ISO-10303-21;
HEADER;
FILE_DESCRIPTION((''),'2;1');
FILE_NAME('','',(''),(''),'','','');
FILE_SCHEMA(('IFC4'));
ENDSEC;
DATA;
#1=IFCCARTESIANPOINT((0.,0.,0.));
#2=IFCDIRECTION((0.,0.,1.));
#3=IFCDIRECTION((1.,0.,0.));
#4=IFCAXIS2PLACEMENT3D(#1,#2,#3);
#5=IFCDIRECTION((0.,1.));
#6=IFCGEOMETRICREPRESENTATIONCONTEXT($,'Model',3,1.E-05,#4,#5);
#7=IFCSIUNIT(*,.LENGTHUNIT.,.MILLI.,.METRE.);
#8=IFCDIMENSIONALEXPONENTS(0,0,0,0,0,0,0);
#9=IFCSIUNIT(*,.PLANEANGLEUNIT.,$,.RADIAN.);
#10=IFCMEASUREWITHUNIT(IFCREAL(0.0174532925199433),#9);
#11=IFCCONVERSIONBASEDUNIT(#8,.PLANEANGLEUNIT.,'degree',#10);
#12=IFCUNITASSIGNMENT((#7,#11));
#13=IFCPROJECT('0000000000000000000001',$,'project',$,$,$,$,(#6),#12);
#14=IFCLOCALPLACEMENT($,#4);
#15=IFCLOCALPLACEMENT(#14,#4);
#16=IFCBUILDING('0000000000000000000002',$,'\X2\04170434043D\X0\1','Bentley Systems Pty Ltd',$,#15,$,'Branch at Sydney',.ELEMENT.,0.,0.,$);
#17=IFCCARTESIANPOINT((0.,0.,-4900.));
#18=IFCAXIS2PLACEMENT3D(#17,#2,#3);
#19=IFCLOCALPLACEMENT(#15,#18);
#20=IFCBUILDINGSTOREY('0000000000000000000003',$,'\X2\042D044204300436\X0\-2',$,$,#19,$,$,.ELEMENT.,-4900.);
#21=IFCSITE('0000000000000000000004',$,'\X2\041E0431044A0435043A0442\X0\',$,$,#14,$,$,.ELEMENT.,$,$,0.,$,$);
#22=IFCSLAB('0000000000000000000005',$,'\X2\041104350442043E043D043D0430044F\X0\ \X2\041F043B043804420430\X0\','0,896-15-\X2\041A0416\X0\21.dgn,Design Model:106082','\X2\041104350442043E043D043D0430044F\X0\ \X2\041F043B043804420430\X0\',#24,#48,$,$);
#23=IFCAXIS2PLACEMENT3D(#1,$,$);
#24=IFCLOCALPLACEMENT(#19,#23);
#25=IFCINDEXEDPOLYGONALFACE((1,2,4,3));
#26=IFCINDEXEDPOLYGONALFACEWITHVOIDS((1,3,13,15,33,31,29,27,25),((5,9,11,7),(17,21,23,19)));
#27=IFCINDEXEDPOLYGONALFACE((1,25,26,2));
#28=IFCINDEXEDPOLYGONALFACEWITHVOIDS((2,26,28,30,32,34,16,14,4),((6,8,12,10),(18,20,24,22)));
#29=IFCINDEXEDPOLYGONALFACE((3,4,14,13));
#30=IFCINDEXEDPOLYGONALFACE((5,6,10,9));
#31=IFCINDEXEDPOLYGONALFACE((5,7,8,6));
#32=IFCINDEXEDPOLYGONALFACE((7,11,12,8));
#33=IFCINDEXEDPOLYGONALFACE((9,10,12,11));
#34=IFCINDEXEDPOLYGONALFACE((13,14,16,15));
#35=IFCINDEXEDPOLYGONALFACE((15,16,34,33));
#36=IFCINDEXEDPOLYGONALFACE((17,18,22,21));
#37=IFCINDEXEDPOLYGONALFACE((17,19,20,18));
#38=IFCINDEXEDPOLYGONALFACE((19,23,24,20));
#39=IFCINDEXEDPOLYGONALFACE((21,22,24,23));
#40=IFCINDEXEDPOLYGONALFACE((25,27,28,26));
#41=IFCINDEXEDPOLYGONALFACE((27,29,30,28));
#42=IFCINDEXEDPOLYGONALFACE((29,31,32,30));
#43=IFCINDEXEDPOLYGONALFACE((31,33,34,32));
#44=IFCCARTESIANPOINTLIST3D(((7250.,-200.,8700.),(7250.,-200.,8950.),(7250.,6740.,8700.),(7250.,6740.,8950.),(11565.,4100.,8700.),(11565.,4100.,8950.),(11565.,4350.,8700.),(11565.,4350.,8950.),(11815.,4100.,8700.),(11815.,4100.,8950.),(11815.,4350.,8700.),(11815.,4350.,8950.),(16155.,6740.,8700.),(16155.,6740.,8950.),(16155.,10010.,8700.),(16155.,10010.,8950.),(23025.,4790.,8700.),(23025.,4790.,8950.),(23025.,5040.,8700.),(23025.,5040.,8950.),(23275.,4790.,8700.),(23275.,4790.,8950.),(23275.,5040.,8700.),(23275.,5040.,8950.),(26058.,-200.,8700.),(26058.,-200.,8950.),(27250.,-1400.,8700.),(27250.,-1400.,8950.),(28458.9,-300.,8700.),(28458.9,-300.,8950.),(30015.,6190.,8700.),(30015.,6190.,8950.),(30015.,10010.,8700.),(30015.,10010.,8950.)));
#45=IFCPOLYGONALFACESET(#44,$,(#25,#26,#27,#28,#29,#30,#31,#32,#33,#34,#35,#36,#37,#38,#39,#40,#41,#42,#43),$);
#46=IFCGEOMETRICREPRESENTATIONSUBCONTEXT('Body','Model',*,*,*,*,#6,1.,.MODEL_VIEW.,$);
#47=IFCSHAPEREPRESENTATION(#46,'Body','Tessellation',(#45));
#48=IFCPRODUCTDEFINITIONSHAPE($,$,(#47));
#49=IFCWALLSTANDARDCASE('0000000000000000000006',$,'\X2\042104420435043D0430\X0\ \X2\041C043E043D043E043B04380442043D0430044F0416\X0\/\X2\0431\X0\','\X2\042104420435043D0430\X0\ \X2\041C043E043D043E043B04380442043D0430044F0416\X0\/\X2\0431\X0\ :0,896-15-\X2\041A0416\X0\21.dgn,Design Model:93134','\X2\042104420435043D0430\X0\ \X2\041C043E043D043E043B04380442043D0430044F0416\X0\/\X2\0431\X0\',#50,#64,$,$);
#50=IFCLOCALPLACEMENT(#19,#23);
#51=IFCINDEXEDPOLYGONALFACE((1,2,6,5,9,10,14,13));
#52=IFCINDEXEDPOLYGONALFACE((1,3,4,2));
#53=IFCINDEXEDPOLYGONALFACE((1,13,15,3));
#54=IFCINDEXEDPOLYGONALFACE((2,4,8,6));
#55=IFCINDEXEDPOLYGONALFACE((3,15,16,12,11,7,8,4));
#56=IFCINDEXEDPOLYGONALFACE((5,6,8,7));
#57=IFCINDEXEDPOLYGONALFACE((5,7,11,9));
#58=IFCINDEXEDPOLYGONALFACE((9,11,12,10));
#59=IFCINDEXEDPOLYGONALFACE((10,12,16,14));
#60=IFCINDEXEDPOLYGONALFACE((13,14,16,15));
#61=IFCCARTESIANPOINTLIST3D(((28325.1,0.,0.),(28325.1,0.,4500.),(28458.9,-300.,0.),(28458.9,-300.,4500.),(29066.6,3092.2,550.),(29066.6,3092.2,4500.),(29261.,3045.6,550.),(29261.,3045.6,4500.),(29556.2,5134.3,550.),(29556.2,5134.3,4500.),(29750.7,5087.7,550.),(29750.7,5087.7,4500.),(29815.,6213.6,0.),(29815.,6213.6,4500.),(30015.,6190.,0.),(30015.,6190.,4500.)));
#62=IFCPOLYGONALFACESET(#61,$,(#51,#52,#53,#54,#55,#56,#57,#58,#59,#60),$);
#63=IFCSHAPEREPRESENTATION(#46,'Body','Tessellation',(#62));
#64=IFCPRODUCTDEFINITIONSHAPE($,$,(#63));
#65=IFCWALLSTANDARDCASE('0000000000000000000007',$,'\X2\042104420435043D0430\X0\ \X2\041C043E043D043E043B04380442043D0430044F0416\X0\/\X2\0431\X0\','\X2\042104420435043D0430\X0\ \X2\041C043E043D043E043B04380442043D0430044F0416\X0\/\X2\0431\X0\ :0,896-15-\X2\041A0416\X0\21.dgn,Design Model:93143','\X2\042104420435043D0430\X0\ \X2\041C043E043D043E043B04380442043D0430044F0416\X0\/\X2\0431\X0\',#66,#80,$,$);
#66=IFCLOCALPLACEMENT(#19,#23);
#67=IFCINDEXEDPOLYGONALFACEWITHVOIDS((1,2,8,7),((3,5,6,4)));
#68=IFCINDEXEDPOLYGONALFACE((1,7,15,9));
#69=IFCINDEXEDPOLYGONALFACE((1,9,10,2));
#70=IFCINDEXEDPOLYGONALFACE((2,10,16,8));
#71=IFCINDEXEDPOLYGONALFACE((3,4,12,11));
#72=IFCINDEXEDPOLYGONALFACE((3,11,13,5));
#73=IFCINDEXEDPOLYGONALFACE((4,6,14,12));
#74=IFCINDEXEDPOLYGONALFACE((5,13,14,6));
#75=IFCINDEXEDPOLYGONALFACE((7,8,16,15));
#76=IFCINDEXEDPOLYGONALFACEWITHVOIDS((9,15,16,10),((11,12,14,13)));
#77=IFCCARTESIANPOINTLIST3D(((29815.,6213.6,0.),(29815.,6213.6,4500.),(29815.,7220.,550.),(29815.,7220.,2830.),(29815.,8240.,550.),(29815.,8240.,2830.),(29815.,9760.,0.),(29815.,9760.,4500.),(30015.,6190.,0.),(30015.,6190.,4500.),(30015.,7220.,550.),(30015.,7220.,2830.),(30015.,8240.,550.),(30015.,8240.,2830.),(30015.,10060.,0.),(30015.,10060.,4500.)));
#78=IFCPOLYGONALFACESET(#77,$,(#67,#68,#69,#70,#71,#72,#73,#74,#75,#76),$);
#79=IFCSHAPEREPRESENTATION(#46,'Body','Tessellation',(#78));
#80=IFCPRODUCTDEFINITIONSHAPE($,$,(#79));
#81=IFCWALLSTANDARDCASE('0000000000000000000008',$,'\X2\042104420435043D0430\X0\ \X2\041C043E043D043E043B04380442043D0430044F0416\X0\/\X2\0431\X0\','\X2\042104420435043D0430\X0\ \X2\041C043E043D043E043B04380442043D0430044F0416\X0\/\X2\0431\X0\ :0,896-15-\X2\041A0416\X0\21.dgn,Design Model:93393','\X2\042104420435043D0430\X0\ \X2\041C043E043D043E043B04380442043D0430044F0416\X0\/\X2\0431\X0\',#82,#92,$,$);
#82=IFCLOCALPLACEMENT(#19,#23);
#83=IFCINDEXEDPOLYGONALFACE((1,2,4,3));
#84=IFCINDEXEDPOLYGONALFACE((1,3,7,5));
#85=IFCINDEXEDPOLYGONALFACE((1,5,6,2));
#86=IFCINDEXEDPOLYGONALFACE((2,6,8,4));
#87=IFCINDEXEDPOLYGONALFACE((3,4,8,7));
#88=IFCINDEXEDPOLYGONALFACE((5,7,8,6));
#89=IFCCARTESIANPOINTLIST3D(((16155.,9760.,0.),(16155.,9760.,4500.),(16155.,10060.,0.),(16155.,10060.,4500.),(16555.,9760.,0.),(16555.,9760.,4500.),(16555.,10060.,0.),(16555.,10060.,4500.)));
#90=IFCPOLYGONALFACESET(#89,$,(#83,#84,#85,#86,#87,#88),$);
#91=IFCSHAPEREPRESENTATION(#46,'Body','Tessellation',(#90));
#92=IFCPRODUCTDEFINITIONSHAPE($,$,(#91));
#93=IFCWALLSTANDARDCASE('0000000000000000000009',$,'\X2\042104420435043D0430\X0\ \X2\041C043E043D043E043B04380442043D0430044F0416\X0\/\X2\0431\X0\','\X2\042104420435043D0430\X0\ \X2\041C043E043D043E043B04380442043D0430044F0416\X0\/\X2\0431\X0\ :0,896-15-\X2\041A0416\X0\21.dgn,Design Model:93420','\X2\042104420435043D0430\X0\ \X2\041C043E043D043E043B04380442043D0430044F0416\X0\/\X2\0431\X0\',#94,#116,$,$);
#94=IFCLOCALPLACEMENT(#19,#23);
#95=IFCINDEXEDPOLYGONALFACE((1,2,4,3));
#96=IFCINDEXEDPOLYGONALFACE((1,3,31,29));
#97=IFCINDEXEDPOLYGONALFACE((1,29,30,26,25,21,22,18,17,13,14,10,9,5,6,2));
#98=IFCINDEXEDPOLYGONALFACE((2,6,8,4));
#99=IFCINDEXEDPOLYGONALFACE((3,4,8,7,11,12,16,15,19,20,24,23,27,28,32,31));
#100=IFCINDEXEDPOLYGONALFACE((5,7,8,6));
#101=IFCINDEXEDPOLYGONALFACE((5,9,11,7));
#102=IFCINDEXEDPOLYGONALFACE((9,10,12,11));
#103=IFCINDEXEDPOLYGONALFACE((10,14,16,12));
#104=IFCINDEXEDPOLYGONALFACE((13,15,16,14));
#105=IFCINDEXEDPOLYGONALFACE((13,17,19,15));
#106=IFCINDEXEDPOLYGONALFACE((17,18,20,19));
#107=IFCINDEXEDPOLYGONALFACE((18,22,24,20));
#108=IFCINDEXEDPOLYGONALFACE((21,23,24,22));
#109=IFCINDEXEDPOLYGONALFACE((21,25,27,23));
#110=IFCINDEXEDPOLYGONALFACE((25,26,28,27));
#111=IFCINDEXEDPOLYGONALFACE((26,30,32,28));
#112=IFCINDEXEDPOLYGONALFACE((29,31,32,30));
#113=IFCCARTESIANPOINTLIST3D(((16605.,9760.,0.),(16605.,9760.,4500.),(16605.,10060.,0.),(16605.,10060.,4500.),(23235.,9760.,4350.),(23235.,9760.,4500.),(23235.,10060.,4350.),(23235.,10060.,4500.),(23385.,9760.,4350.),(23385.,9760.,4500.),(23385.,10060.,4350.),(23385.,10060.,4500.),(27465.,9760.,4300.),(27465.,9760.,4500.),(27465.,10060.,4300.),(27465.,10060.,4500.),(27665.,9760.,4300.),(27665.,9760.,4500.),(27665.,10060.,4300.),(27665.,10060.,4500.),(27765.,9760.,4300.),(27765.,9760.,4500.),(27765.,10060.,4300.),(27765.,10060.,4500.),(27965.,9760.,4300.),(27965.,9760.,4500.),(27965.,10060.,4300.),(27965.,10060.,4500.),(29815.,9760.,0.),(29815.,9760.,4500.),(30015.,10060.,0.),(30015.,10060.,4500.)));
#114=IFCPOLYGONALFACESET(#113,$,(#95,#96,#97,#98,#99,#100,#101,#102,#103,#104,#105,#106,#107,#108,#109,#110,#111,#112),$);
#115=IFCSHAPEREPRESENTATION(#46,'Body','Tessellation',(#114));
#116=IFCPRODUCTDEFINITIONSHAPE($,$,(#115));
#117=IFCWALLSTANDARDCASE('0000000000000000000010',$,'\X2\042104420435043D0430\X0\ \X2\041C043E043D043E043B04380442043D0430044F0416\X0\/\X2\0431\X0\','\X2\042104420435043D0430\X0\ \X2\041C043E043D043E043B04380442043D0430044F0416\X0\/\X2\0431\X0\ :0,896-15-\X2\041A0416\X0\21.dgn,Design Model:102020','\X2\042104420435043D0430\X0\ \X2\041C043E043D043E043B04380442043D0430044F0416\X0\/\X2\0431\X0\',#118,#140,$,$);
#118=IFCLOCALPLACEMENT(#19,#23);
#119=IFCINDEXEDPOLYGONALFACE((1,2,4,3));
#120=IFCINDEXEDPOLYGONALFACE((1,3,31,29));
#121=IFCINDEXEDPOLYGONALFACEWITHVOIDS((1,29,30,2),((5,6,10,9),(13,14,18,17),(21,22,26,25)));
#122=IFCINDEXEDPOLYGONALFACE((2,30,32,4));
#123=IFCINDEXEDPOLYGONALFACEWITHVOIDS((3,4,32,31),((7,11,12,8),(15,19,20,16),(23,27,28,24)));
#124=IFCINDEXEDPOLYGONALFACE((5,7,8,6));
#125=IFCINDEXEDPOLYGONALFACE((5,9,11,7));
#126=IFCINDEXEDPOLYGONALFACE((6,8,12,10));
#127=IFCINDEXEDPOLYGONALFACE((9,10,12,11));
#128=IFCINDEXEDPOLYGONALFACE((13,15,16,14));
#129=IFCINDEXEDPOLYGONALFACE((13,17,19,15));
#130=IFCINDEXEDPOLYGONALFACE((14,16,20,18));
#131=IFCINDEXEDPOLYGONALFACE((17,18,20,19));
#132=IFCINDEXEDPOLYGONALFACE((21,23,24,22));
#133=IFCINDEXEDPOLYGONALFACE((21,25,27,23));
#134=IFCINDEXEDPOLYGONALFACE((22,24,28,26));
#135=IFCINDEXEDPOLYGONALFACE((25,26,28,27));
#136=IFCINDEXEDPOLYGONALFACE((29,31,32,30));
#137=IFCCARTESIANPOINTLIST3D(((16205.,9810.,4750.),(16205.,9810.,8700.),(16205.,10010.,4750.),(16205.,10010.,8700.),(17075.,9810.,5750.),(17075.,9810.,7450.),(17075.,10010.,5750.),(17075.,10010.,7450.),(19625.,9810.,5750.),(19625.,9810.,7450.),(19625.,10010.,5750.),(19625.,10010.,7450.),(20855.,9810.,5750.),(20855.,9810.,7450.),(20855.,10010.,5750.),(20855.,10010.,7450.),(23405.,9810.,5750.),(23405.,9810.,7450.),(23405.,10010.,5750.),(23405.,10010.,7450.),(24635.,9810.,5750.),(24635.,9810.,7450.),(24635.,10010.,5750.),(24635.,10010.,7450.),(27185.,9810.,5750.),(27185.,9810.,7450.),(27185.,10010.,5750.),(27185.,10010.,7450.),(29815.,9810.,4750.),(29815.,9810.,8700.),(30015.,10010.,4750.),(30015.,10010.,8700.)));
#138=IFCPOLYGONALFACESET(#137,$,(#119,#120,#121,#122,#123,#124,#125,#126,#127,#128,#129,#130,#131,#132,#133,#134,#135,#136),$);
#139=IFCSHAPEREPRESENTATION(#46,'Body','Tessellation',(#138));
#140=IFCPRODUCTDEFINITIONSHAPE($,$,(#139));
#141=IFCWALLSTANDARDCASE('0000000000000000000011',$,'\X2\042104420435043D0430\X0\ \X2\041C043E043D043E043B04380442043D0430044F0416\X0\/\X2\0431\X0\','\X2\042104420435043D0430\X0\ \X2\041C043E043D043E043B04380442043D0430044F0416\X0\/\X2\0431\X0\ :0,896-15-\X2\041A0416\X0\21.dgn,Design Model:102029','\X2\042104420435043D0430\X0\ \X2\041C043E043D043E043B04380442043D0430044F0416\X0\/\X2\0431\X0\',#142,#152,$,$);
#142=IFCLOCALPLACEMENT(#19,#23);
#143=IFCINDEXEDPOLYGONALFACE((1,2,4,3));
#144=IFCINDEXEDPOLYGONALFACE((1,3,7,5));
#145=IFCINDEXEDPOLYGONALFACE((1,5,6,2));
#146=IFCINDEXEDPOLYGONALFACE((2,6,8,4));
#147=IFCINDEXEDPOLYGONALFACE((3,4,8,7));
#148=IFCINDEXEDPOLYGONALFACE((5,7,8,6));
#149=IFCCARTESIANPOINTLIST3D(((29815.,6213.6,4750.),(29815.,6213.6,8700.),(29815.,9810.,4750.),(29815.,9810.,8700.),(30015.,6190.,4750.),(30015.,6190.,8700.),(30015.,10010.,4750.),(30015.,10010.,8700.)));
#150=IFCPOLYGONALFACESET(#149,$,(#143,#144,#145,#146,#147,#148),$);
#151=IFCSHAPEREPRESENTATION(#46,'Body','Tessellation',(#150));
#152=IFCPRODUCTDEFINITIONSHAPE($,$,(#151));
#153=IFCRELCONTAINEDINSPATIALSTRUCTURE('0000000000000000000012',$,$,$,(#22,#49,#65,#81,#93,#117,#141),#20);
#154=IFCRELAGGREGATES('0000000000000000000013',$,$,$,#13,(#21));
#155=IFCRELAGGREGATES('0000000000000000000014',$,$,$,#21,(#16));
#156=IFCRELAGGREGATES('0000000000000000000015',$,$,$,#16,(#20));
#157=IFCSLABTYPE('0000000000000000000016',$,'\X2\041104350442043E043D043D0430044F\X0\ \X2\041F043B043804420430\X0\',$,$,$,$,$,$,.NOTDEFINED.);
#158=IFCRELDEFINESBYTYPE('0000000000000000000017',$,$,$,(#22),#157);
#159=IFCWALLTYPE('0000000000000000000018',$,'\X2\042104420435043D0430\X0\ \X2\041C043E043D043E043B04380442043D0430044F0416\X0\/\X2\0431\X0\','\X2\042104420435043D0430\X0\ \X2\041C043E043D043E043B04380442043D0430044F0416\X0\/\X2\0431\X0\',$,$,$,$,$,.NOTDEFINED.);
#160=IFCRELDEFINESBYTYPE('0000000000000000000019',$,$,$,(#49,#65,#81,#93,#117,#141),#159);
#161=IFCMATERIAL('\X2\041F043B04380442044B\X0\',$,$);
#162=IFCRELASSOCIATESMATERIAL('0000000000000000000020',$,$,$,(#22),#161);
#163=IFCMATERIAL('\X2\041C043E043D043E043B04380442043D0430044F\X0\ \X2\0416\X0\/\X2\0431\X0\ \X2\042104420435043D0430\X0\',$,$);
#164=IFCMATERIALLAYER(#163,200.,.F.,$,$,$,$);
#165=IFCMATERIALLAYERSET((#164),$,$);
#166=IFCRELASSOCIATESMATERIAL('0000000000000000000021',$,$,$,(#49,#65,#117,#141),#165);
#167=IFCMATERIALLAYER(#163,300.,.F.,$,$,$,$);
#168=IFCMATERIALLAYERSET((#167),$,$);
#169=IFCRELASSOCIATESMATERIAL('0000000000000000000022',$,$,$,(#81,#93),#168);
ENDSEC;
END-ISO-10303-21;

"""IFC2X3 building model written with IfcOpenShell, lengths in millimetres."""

from ifc_helpers import new_model, entity, si_unit, converted_unit, direction, frame, frame_2d, origin_with_axes, place, context, subcontext, project, spatial, polyline, rectangle, outline, extrude, material, layer, layer_set, layer_usage, type_object, element, save


model = new_model("IFC2X3")

# Units and contexts
model_context = context("Model", 3, precision=1e-05, world=origin_with_axes(), true_north=direction((0.0, 1.0)))
body_context = subcontext(model_context, "Body", "Model", "MODEL_VIEW", scale=1.0)
ifc_project = project(units=[si_unit("LENGTHUNIT", "METRE", prefix="MILLI"), converted_unit("PLANEANGLEUNIT", "degree", entity("IfcReal", 0.0174532925199433), si_unit("PLANEANGLEUNIT", "RADIAN"), dimensions=[0, 0, 0, 0, 0, 0, 0])], contexts=[model_context])

# Site, building, storey
site_placement = place(None, origin_with_axes())
site = spatial("IfcSite", under=ifc_project, at=site_placement, Name="Объект", CompositionType="ELEMENT", RefElevation=0.0)
building_placement = place(site_placement, origin_with_axes())
building = spatial("IfcBuilding", under=site, at=building_placement, Name="Здн1", Description="Bentley Systems Pty Ltd", LongName="Branch at Sydney", CompositionType="ELEMENT", ElevationOfRefHeight=0.0, ElevationOfTerrain=0.0)
storey_placement = place(building_placement, frame((0.0, 0.0, -4900.0), z_axis=(0.0, 0.0, 1.0), x_axis=(1.0, 0.0, 0.0)))
storey = spatial("IfcBuildingStorey", under=building, at=storey_placement, Name="Этаж-2", CompositionType="ELEMENT", Elevation=-4900.0)

# Slab, openings
ifc_material_1 = material(Name="Плиты")
slab_type = type_object("IfcSlabType", Name="Бетонная Плита", PredefinedType="NOTDEFINED")
slab_placement = place(storey_placement, frame((30015.0, 10010.0, 8950.0), z_axis=(0.0, 0.0, -1.0), x_axis=(0.0, -1.0, 0.0)))
slab = element("IfcSlab", 1, at=slab_placement, inside=storey, type_object=slab_type, material=ifc_material_1, Name="Бетонная Плита", Description="0,896-15-КЖ21.dgn,Design Model:106082", ObjectType="Бетонная Плита", context=body_context, shape_type="SweptSolid", body=[
    extrude(outline(polyline([(0.0, 0.0), (3820.0, 0.0), (10310.0, 1556.1), (11410.0, 2765.0), (10210.0, 3957.0), (10210.0, 22765.0), (3270.0, 22765.0), (3270.0, 13860.0), (0.0, 13860.0), (0.0, 0.0)])), origin_with_axes(), (0.0, 0.0, 1.0), 250.0),
])
opening_1_placement = place(slab_placement, frame((4970.0, 6740.0, 0.0), z_axis=(0.0, 0.0, 1.0), x_axis=(1.0, 0.0, 0.0)))
element("IfcOpeningElement", 2, at=opening_1_placement, cuts=slab, ObjectType="Opening", context=body_context, shape_type="SweptSolid", body=[
    extrude(rectangle(XDim=250.0, YDim=250.0, at=frame_2d((-125.0, 125.0), x_axis=(0.0, 1.0))), frame((0.0, 0.0, 375.0), z_axis=(0.0, 0.0, -1.0), x_axis=(-1.0, 0.0, 0.0)), (0.0, 0.0, 1.0), 750.0),
])
opening_2_placement = place(slab_placement, frame((5660.0, 18200.0, 0.0), z_axis=(0.0, 0.0, 1.0), x_axis=(1.0, 0.0, 0.0)))
element("IfcOpeningElement", 3, at=opening_2_placement, cuts=slab, ObjectType="Opening", context=body_context, shape_type="SweptSolid", body=[
    extrude(rectangle(XDim=250.0, YDim=250.0, at=frame_2d((-125.0, 125.0), x_axis=(0.0, 1.0))), frame((0.0, 0.0, 375.0), z_axis=(0.0, 0.0, -1.0), x_axis=(-1.0, 0.0, 0.0)), (0.0, 0.0, 1.0), 750.0),
])

# Walls, openings
ifc_material_2 = material(Name="Монолитная Ж/б Стена")
ifc_layer_1 = layer(ifc_material_2, 200.0, ventilated=False)
ifc_layer_set_1 = layer_set([ifc_layer_1])
ifc_layer_usage_1 = layer_usage(ifc_layer_set_1, "AXIS2", "POSITIVE", 0.0)
wall_type = type_object("IfcWallType", Name="Стена МонолитнаяЖ/б", Description="Стена МонолитнаяЖ/б", PredefinedType="NOTDEFINED")
wall_1_placement = place(storey_placement, frame((28458.9, -300.0, 0.0), z_axis=(0.0, 0.0, 1.0), x_axis=(0.233165, 0.972437, 0.0)))
wall_1 = element("IfcWallStandardCase", 4, at=wall_1_placement, inside=storey, type_object=wall_type, material=ifc_layer_usage_1, Name="Стена МонолитнаяЖ/б", Description="Стена МонолитнаяЖ/б :0,896-15-КЖ21.dgn,Design Model:93134", ObjectType="Стена МонолитнаяЖ/б", context=body_context, shape_type="SweptSolid", body=[
    extrude(outline(polyline([(6650.3, 200.0), (260.6, 200.0), (0.0, 0.0), (6673.9, 0.0), (6650.3, 200.0)])), origin_with_axes(), (0.0, 0.0, 1.0), 4500.0),
])
opening_3_placement = place(wall_1_placement, frame((3440.4, 0.0, 550.0), z_axis=(0.0, 0.0, 1.0), x_axis=(1.0, 0.0, 0.0)))
element("IfcOpeningElement", 5, at=opening_3_placement, cuts=wall_1, ObjectType="Opening", context=body_context, shape_type="SweptSolid", body=[
    extrude(rectangle(XDim=3950.0, YDim=2100.0, at=frame_2d((-1050.0, 1975.0), x_axis=(0.0, -1.0))), frame((0.0, 0.0, 0.0), z_axis=(0.0, 1.0, 0.0), x_axis=(-1.0, 0.0, 0.0)), (0.0, 0.0, 1.0), 200.0),
])
wall_2_placement = place(storey_placement, frame((30015.0, 6190.0, 0.0), z_axis=(0.0, 0.0, 1.0), x_axis=(0.0, 1.0, 0.0)))
wall_2 = element("IfcWallStandardCase", 6, at=wall_2_placement, inside=storey, type_object=wall_type, material=ifc_layer_usage_1, Name="Стена МонолитнаяЖ/б", Description="Стена МонолитнаяЖ/б :0,896-15-КЖ21.dgn,Design Model:93143", ObjectType="Стена МонолитнаяЖ/б", context=body_context, shape_type="SweptSolid", body=[
    extrude(outline(polyline([(3570.0, 200.0), (23.6, 200.0), (0.0, 0.0), (3870.0, 0.0), (3570.0, 200.0)])), origin_with_axes(), (0.0, 0.0, 1.0), 4500.0),
])
opening_4_placement = place(wall_2_placement, frame((1030.0, 0.0, 550.0), z_axis=(0.0, 0.0, 1.0), x_axis=(1.0, 0.0, 0.0)))
element("IfcOpeningElement", 7, at=opening_4_placement, cuts=wall_2, ObjectType="Opening", context=body_context, shape_type="SweptSolid", body=[
    extrude(rectangle(XDim=2280.0, YDim=1020.0, at=frame_2d((-510.0, 1140.0), x_axis=(0.0, -1.0))), frame((0.0, 0.0, 0.0), z_axis=(0.0, 1.0, 0.0), x_axis=(-1.0, 0.0, 0.0)), (0.0, 0.0, 1.0), 200.0),
])

# Wall
ifc_layer_2 = layer(ifc_material_2, 300.0, ventilated=False)
ifc_layer_set_2 = layer_set([ifc_layer_2])
ifc_layer_usage_2 = layer_usage(ifc_layer_set_2, "AXIS2", "POSITIVE", 0.0)
wall_3_placement = place(storey_placement, frame((16555.0, 10060.0, 0.0), z_axis=(0.0, 0.0, 1.0), x_axis=(-1.0, 0.0, 0.0)))
element("IfcWallStandardCase", 8, at=wall_3_placement, inside=storey, type_object=wall_type, material=ifc_layer_usage_2, Name="Стена МонолитнаяЖ/б", Description="Стена МонолитнаяЖ/б :0,896-15-КЖ21.dgn,Design Model:93393", ObjectType="Стена МонолитнаяЖ/б", context=body_context, shape_type="SweptSolid", body=[
    extrude(rectangle(XDim=400.0, YDim=300.0, at=frame_2d((200.0, 150.0), x_axis=(1.0, 0.0))), origin_with_axes(), (0.0, 0.0, 1.0), 4500.0),
])

# Walls, openings
wall_4_placement = place(storey_placement, frame((30015.0, 10060.0, 0.0), z_axis=(0.0, 0.0, 1.0), x_axis=(-1.0, 0.0, 0.0)))
wall_4 = element("IfcWallStandardCase", 9, at=wall_4_placement, inside=storey, type_object=wall_type, material=ifc_layer_usage_2, Name="Стена МонолитнаяЖ/б", Description="Стена МонолитнаяЖ/б :0,896-15-КЖ21.dgn,Design Model:93420", ObjectType="Стена МонолитнаяЖ/б", context=body_context, shape_type="SweptSolid", body=[
    extrude(outline(polyline([(200.0, 300.0), (0.0, 0.0), (13410.0, 0.0), (13410.0, 300.0), (200.0, 300.0)])), origin_with_axes(), (0.0, 0.0, 1.0), 4500.0),
])
opening_5_placement = place(wall_4_placement, frame((6630.0, 0.0, 4350.0), z_axis=(0.0, 0.0, 1.0), x_axis=(1.0, 0.0, 0.0)))
element("IfcOpeningElement", 10, at=opening_5_placement, cuts=wall_4, ObjectType="Opening", context=body_context, shape_type="SweptSolid", body=[
    extrude(rectangle(XDim=150.0, YDim=150.0, at=frame_2d((-75.0, 75.0), x_axis=(0.0, -1.0))), frame((0.0, 0.0, 0.0), z_axis=(0.0, 1.0, 0.0), x_axis=(-1.0, 0.0, 0.0)), (0.0, 0.0, 1.0), 300.0),
])
opening_6_placement = place(wall_4_placement, frame((2350.0, 0.0, 4300.0), z_axis=(0.0, 0.0, 1.0), x_axis=(1.0, 0.0, 0.0)))
element("IfcOpeningElement", 11, at=opening_6_placement, cuts=wall_4, ObjectType="Opening", context=body_context, shape_type="SweptSolid", body=[
    extrude(rectangle(XDim=200.0, YDim=200.0, at=frame_2d((-100.0, 100.0), x_axis=(0.0, -1.0))), frame((0.0, 0.0, 0.0), z_axis=(0.0, 1.0, 0.0), x_axis=(-1.0, 0.0, 0.0)), (0.0, 0.0, 1.0), 300.0),
])
opening_7_placement = place(wall_4_placement, frame((2050.0, 0.0, 4300.0), z_axis=(0.0, 0.0, 1.0), x_axis=(1.0, 0.0, 0.0)))
element("IfcOpeningElement", 12, at=opening_7_placement, cuts=wall_4, ObjectType="Opening", context=body_context, shape_type="SweptSolid", body=[
    extrude(rectangle(XDim=200.0, YDim=200.0, at=frame_2d((-100.0, 100.0), x_axis=(0.0, -1.0))), frame((0.0, 0.0, 0.0), z_axis=(0.0, 1.0, 0.0), x_axis=(-1.0, 0.0, 0.0)), (0.0, 0.0, 1.0), 300.0),
])
wall_5_placement = place(storey_placement, frame((30015.0, 10010.0, 4750.0), z_axis=(0.0, 0.0, 1.0), x_axis=(-1.0, 0.0, 0.0)))
wall_5 = element("IfcWallStandardCase", 13, at=wall_5_placement, inside=storey, type_object=wall_type, material=ifc_layer_usage_1, Name="Стена МонолитнаяЖ/б", Description="Стена МонолитнаяЖ/б :0,896-15-КЖ21.dgn,Design Model:102020", ObjectType="Стена МонолитнаяЖ/б", context=body_context, shape_type="SweptSolid", body=[
    extrude(outline(polyline([(200.0, 200.0), (0.0, 0.0), (13810.0, 0.0), (13810.0, 200.0), (200.0, 200.0)])), origin_with_axes(), (0.0, 0.0, 1.0), 3950.0),
])
opening_8_placement = place(wall_5_placement, frame((10390.0, 0.0, 1000.0), z_axis=(0.0, 0.0, 1.0), x_axis=(1.0, 0.0, 0.0)))
element("IfcOpeningElement", 14, at=opening_8_placement, cuts=wall_5, ObjectType="Opening", context=body_context, shape_type="SweptSolid", body=[
    extrude(rectangle(XDim=1700.0, YDim=2550.0, at=frame_2d((-1275.0, 850.0), x_axis=(0.0, -1.0))), frame((0.0, 0.0, 0.0), z_axis=(0.0, 1.0, 0.0), x_axis=(-1.0, 0.0, 0.0)), (0.0, 0.0, 1.0), 200.0),
])
opening_9_placement = place(wall_5_placement, frame((6610.0, 0.0, 1000.0), z_axis=(0.0, 0.0, 1.0), x_axis=(1.0, 0.0, 0.0)))
element("IfcOpeningElement", 15, at=opening_9_placement, cuts=wall_5, ObjectType="Opening", context=body_context, shape_type="SweptSolid", body=[
    extrude(rectangle(XDim=1700.0, YDim=2550.0, at=frame_2d((-1275.0, 850.0), x_axis=(0.0, -1.0))), frame((0.0, 0.0, 0.0), z_axis=(0.0, 1.0, 0.0), x_axis=(-1.0, 0.0, 0.0)), (0.0, 0.0, 1.0), 200.0),
])
opening_10_placement = place(wall_5_placement, frame((2830.0, 0.0, 1000.0), z_axis=(0.0, 0.0, 1.0), x_axis=(1.0, 0.0, 0.0)))
element("IfcOpeningElement", 16, at=opening_10_placement, cuts=wall_5, ObjectType="Opening", context=body_context, shape_type="SweptSolid", body=[
    extrude(rectangle(XDim=1700.0, YDim=2550.0, at=frame_2d((-1275.0, 850.0), x_axis=(0.0, -1.0))), frame((0.0, 0.0, 0.0), z_axis=(0.0, 1.0, 0.0), x_axis=(-1.0, 0.0, 0.0)), (0.0, 0.0, 1.0), 200.0),
])

# Wall
wall_6_placement = place(storey_placement, frame((30015.0, 10010.0, 4750.0), z_axis=(0.0, 0.0, 1.0), x_axis=(0.0, -1.0, 0.0)))
element("IfcWallStandardCase", 17, at=wall_6_placement, inside=storey, type_object=wall_type, material=ifc_layer_usage_1, Name="Стена МонолитнаяЖ/б", Description="Стена МонолитнаяЖ/б :0,896-15-КЖ21.dgn,Design Model:102029", ObjectType="Стена МонолитнаяЖ/б", context=body_context, shape_type="SweptSolid", body=[
    extrude(outline(polyline([(3820.0, 0.0), (0.0, 0.0), (200.0, -200.0), (3796.4, -200.0), (3820.0, 0.0)])), origin_with_axes(), (0.0, 0.0, 1.0), 3950.0),
])

save(model, "model.ifc")
